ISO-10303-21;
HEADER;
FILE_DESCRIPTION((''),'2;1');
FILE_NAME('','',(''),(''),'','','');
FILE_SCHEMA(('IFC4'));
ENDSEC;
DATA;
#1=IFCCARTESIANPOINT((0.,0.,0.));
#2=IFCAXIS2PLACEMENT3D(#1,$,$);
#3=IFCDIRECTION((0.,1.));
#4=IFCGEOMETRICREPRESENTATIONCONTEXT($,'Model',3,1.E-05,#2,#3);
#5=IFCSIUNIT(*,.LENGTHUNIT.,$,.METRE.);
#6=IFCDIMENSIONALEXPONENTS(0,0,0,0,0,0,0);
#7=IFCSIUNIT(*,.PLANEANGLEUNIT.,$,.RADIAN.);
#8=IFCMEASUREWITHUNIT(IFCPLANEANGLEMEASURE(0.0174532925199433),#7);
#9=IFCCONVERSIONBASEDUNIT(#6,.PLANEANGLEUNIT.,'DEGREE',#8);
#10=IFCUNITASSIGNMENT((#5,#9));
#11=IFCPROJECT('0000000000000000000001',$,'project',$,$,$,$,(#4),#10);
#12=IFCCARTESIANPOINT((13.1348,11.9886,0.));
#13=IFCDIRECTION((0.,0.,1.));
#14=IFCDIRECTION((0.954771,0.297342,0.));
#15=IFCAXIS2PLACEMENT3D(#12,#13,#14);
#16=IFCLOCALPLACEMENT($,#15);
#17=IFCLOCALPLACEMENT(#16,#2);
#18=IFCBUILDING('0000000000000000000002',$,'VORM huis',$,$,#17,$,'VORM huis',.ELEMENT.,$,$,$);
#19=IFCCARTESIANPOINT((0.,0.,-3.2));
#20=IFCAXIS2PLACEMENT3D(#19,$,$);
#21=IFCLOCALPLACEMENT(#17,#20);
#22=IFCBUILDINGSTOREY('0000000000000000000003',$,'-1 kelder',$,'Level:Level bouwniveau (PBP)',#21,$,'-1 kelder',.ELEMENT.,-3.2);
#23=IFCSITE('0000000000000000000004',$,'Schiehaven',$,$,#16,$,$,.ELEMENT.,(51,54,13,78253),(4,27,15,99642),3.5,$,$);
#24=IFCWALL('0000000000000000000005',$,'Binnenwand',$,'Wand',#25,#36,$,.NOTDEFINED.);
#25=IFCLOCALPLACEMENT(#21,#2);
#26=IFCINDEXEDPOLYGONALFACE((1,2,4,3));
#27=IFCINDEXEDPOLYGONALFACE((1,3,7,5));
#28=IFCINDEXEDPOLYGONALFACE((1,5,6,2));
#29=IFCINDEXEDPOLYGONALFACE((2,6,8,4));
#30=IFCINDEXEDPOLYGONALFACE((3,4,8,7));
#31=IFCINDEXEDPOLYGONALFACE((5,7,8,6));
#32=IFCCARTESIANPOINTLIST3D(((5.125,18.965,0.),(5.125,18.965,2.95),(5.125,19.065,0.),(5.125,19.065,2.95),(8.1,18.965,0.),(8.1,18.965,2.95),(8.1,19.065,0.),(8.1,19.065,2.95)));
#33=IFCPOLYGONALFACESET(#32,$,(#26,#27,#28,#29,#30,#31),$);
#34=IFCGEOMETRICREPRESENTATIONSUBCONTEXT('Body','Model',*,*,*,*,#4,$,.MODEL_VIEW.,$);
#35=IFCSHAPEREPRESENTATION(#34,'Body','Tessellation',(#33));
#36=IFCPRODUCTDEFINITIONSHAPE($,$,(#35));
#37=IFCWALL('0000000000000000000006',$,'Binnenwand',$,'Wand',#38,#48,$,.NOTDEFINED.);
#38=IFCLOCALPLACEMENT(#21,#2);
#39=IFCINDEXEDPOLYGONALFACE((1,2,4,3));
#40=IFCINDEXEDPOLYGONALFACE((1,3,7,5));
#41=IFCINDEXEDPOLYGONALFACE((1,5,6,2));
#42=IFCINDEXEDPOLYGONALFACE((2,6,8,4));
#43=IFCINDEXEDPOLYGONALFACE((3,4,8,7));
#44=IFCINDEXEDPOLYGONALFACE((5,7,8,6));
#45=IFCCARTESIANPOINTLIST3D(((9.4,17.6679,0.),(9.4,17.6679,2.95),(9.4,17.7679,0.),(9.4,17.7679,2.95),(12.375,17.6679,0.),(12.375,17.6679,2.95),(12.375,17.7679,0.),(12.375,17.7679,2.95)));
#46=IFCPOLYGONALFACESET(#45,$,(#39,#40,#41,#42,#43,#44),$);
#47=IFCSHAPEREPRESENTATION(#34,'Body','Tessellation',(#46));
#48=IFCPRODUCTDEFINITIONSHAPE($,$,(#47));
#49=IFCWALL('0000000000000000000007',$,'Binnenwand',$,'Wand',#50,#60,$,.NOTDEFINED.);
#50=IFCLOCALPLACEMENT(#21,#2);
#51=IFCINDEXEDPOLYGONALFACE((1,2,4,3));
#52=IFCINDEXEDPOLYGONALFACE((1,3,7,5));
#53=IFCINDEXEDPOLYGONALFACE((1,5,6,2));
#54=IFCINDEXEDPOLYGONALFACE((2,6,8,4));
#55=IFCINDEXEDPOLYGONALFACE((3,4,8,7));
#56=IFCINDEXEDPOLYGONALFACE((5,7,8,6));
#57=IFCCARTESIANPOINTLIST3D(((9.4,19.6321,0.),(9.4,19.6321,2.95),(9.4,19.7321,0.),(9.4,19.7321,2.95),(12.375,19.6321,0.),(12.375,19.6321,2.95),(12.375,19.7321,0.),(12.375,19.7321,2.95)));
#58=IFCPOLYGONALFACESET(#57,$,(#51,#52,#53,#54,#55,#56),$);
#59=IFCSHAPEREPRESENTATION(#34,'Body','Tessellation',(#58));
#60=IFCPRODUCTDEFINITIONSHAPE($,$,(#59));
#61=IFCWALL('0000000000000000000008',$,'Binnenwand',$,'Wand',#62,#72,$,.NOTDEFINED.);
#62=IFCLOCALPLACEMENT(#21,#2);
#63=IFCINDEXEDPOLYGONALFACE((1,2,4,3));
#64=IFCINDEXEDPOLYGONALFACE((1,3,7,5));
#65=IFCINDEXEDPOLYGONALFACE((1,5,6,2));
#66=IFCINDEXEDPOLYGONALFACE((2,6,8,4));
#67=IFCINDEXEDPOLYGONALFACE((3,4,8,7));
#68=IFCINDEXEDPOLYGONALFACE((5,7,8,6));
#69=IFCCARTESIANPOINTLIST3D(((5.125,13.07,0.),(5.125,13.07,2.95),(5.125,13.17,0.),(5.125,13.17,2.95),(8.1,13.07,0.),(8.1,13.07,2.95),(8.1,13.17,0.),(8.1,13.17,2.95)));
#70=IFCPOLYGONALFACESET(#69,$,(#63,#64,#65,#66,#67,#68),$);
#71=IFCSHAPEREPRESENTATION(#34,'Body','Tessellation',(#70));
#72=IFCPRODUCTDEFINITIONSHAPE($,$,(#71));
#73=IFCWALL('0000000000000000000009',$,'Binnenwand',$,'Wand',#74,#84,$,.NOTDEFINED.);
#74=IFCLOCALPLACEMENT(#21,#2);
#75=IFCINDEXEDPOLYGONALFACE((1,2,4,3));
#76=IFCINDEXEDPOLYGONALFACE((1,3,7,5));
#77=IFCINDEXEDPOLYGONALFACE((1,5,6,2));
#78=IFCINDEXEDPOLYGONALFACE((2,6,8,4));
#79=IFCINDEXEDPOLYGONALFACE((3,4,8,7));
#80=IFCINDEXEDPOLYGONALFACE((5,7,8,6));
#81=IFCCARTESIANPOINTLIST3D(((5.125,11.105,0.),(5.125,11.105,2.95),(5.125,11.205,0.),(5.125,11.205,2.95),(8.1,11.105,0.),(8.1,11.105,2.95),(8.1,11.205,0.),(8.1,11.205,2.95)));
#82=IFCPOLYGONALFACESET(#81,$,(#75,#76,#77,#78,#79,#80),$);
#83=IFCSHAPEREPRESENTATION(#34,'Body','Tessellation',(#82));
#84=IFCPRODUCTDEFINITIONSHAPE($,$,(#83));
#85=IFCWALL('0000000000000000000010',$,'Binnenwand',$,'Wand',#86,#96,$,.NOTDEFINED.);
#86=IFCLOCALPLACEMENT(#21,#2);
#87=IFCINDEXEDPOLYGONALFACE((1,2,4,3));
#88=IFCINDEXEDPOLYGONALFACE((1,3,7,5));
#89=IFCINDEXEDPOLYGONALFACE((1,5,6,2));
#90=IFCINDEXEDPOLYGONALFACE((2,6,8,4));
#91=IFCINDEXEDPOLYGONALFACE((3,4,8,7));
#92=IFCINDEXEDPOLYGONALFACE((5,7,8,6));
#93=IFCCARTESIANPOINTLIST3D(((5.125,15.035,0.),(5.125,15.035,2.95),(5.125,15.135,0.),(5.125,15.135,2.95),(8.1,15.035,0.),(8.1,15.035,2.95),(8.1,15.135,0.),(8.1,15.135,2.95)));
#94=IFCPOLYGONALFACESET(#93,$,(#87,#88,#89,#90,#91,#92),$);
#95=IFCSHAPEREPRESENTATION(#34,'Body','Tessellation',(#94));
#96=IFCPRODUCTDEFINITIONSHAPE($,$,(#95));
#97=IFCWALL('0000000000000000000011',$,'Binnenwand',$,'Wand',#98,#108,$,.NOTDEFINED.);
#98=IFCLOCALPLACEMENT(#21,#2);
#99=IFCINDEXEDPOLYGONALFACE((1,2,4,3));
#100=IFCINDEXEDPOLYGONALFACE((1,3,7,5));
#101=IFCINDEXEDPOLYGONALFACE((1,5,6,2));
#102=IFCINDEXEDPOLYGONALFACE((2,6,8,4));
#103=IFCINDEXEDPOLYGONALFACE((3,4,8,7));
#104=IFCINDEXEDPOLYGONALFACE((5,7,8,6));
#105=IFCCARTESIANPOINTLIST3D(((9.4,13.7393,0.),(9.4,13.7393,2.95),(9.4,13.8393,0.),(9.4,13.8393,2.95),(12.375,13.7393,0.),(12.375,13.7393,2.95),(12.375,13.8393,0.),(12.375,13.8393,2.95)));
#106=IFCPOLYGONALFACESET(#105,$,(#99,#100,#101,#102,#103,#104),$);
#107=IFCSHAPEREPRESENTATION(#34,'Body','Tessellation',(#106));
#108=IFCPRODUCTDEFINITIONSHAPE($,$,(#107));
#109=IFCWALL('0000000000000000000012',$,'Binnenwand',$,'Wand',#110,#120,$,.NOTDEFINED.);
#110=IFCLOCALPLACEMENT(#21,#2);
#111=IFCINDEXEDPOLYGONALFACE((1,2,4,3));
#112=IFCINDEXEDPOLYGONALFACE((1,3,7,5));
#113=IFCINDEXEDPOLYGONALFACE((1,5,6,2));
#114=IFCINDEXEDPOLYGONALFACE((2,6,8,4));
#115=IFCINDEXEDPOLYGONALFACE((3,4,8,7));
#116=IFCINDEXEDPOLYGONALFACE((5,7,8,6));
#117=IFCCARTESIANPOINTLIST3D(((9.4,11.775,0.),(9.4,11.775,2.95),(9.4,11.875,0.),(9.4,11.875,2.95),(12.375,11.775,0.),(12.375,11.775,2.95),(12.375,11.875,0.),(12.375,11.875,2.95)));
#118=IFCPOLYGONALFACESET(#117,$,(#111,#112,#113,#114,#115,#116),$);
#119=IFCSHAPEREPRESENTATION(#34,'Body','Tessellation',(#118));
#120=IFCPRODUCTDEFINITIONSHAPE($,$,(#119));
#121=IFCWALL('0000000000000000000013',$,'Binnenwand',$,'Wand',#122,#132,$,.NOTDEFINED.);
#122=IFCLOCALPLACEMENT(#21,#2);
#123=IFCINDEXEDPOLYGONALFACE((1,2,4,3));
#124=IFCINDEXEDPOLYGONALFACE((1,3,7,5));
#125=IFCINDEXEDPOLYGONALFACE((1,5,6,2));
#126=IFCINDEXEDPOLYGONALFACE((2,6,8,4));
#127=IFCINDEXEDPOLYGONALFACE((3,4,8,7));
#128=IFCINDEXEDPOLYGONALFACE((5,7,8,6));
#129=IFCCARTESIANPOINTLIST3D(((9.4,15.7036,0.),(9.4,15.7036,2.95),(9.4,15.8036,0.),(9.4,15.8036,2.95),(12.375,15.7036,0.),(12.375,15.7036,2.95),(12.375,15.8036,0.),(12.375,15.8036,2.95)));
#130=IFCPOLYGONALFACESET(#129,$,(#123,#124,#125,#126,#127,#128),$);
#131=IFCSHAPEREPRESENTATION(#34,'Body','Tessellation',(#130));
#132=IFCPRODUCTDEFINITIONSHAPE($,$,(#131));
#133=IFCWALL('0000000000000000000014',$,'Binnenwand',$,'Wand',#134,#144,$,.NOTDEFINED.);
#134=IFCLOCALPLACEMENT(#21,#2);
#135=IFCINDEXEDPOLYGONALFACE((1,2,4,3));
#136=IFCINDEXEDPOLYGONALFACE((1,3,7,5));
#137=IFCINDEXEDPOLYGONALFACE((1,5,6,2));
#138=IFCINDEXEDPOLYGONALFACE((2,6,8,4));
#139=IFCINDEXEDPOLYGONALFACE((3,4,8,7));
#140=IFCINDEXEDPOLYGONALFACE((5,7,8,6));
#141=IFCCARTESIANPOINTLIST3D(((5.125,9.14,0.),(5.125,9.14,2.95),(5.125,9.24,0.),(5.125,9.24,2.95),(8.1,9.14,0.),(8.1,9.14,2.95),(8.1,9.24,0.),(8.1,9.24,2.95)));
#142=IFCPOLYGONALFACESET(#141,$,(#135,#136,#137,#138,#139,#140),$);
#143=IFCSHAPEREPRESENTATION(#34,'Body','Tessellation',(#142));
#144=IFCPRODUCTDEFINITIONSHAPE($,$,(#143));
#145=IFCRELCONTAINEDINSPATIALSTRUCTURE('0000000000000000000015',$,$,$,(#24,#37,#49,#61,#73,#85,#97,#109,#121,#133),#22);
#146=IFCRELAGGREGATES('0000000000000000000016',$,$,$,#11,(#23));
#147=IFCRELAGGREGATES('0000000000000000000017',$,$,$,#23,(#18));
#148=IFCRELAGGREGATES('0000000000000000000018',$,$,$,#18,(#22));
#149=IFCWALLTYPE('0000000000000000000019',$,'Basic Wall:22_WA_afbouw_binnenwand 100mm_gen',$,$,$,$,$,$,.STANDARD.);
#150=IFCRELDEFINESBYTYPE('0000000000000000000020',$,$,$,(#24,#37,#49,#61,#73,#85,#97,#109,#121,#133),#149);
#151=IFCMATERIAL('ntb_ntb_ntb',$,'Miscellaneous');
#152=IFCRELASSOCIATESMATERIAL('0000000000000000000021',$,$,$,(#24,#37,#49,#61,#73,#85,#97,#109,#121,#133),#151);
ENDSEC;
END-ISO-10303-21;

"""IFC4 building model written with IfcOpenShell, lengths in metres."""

from ifc_helpers import new_model, entity, si_unit, converted_unit, direction, frame, origin, place, context, subcontext, project, spatial, indexed_curve, outline, extrude, material, type_object, element, save


model = new_model("IFC4")

# Units and contexts
model_context = context("Model", 3, precision=1e-05, world=origin(), true_north=direction((0.0, 1.0)))
body_context = subcontext(model_context, "Body", "Model", "MODEL_VIEW")
ifc_project = project(units=[si_unit("LENGTHUNIT", "METRE"), converted_unit("PLANEANGLEUNIT", "DEGREE", entity("IfcPlaneAngleMeasure", 0.0174532925199433), si_unit("PLANEANGLEUNIT", "RADIAN"), dimensions=[0, 0, 0, 0, 0, 0, 0])], contexts=[model_context])

# Site, building, storey
site_placement = place(None, frame((13.1348, 11.9886, 0.0), z_axis=(0.0, 0.0, 1.0), x_axis=(0.954771, 0.297342, 0.0)))
site = spatial("IfcSite", under=ifc_project, at=site_placement, Name="Schiehaven", CompositionType="ELEMENT", RefLatitude=(51, 54, 13, 78253), RefLongitude=(4, 27, 15, 99642), RefElevation=3.5)
building_placement = place(site_placement, origin())
building = spatial("IfcBuilding", under=site, at=building_placement, Name="VORM huis", LongName="VORM huis", CompositionType="ELEMENT")
storey_placement = place(building_placement, frame((0.0, 0.0, -3.2)))
storey = spatial("IfcBuildingStorey", under=building, at=storey_placement, Name="-1 kelder", ObjectType="Level:Level bouwniveau (PBP)", LongName="-1 kelder", CompositionType="ELEMENT", Elevation=-3.2)

# Walls
ifc_material_1 = material(Name="ntb_ntb_ntb", Category="Miscellaneous")
wall_type_1 = type_object("IfcWallType", Name="Basic Wall:22_WA_afbouw_binnenwand 100mm_gen", PredefinedType="STANDARD")
wall_1_placement = place(storey_placement, frame((8.1, 19.015, 0.0), z_axis=(0.0, 0.0, 1.0), x_axis=(-1.0, 0.0, 0.0)))
element("IfcWall", 1, at=wall_1_placement, inside=storey, type_object=wall_type_1, material=ifc_material_1, Name="Binnenwand", ObjectType="Wand", PredefinedType="NOTDEFINED", context=body_context, shape_type="SweptSolid", body=[
    extrude(outline(indexed_curve([(2.975, 0.05), (0.0, 0.05), (0.0, -0.05), (2.975, -0.05), (2.975, 0.05)], self_intersect=False)), origin(), (0.0, 0.0, 1.0), 2.95),
])
wall_2_placement = place(storey_placement, frame((9.4, 17.7179, 0.0)))
element("IfcWall", 2, at=wall_2_placement, inside=storey, type_object=wall_type_1, material=ifc_material_1, Name="Binnenwand", ObjectType="Wand", PredefinedType="NOTDEFINED", context=body_context, shape_type="SweptSolid", body=[
    extrude(outline(indexed_curve([(2.975, 0.05), (0.0, 0.05), (0.0, -0.05), (2.975, -0.05), (2.975, 0.05)], self_intersect=False)), origin(), (0.0, 0.0, 1.0), 2.95),
])
wall_3_placement = place(storey_placement, frame((9.4, 19.6821, 0.0)))
element("IfcWall", 3, at=wall_3_placement, inside=storey, type_object=wall_type_1, material=ifc_material_1, Name="Binnenwand", ObjectType="Wand", PredefinedType="NOTDEFINED", context=body_context, shape_type="SweptSolid", body=[
    extrude(outline(indexed_curve([(2.975, 0.05), (0.0, 0.05), (0.0, -0.05), (2.975, -0.05), (2.975, 0.05)], self_intersect=False)), origin(), (0.0, 0.0, 1.0), 2.95),
])
for number, where, z_axis, x_axis, name in (
    (4, (8.1, 13.12, 0.0), (0.0, 0.0, 1.0), (-1.0, 0.0, 0.0), "Binnenwand"),
    (5, (8.1, 11.155, 0.0), (0.0, 0.0, 1.0), (-1.0, 0.0, 0.0), "Binnenwand"),
):
    element("IfcWall", number, at=place(storey_placement, frame(where, z_axis=z_axis, x_axis=x_axis)), inside=storey, type_object=wall_type_1, material=ifc_material_1, Name=name, ObjectType="Wand", PredefinedType="NOTDEFINED", context=body_context, shape_type="SweptSolid", body=[
        extrude(outline(indexed_curve([(2.975, 0.05), (0.0, 0.05), (0.0, -0.05), (2.975, -0.05), (2.975, 0.05)], self_intersect=False)), origin(), (0.0, 0.0, 1.0), 2.95),
    ])
wall_4_placement = place(storey_placement, frame((8.1, 15.085, 0.0), z_axis=(0.0, 0.0, 1.0), x_axis=(-1.0, 0.0, 0.0)))
element("IfcWall", 6, at=wall_4_placement, inside=storey, type_object=wall_type_1, material=ifc_material_1, Name="Binnenwand", ObjectType="Wand", PredefinedType="NOTDEFINED", context=body_context, shape_type="SweptSolid", body=[
    extrude(outline(indexed_curve([(2.975, 0.05), (0.0, 0.05), (0.0, -0.05), (2.975, -0.05), (2.975, 0.05)], self_intersect=False)), origin(), (0.0, 0.0, 1.0), 2.95),
])
wall_5_placement = place(storey_placement, frame((9.4, 13.7893, 0.0)))
element("IfcWall", 7, at=wall_5_placement, inside=storey, type_object=wall_type_1, material=ifc_material_1, Name="Binnenwand", ObjectType="Wand", PredefinedType="NOTDEFINED", context=body_context, shape_type="SweptSolid", body=[
    extrude(outline(indexed_curve([(2.975, 0.05), (0.0, 0.05), (0.0, -0.05), (2.975, -0.05), (2.975, 0.05)], self_intersect=False)), origin(), (0.0, 0.0, 1.0), 2.95),
])
wall_6_placement = place(storey_placement, frame((9.4, 11.825, 0.0)))
element("IfcWall", 8, at=wall_6_placement, inside=storey, type_object=wall_type_1, material=ifc_material_1, Name="Binnenwand", ObjectType="Wand", PredefinedType="NOTDEFINED", context=body_context, shape_type="SweptSolid", body=[
    extrude(outline(indexed_curve([(2.975, 0.05), (0.0, 0.05), (0.0, -0.05), (2.975, -0.05), (2.975, 0.05)], self_intersect=False)), origin(), (0.0, 0.0, 1.0), 2.95),
])
wall_7_placement = place(storey_placement, frame((9.4, 15.7536, 0.0)))
element("IfcWall", 9, at=wall_7_placement, inside=storey, type_object=wall_type_1, material=ifc_material_1, Name="Binnenwand", ObjectType="Wand", PredefinedType="NOTDEFINED", context=body_context, shape_type="SweptSolid", body=[
    extrude(outline(indexed_curve([(2.975, 0.05), (0.0, 0.05), (0.0, -0.05), (2.975, -0.05), (2.975, 0.05)], self_intersect=False)), origin(), (0.0, 0.0, 1.0), 2.95),
])
wall_8_placement = place(storey_placement, frame((8.1, 9.19, 0.0), z_axis=(0.0, 0.0, 1.0), x_axis=(-1.0, 0.0, 0.0)))
element("IfcWall", 10, at=wall_8_placement, inside=storey, type_object=wall_type_1, material=ifc_material_1, Name="Binnenwand", ObjectType="Wand", PredefinedType="NOTDEFINED", context=body_context, shape_type="SweptSolid", body=[
    extrude(outline(indexed_curve([(2.975, 0.05), (0.0, 0.05), (0.0, -0.05), (2.975, -0.05), (2.975, 0.05)], self_intersect=False)), origin(), (0.0, 0.0, 1.0), 2.95),
])

save(model, "model.ifc")
